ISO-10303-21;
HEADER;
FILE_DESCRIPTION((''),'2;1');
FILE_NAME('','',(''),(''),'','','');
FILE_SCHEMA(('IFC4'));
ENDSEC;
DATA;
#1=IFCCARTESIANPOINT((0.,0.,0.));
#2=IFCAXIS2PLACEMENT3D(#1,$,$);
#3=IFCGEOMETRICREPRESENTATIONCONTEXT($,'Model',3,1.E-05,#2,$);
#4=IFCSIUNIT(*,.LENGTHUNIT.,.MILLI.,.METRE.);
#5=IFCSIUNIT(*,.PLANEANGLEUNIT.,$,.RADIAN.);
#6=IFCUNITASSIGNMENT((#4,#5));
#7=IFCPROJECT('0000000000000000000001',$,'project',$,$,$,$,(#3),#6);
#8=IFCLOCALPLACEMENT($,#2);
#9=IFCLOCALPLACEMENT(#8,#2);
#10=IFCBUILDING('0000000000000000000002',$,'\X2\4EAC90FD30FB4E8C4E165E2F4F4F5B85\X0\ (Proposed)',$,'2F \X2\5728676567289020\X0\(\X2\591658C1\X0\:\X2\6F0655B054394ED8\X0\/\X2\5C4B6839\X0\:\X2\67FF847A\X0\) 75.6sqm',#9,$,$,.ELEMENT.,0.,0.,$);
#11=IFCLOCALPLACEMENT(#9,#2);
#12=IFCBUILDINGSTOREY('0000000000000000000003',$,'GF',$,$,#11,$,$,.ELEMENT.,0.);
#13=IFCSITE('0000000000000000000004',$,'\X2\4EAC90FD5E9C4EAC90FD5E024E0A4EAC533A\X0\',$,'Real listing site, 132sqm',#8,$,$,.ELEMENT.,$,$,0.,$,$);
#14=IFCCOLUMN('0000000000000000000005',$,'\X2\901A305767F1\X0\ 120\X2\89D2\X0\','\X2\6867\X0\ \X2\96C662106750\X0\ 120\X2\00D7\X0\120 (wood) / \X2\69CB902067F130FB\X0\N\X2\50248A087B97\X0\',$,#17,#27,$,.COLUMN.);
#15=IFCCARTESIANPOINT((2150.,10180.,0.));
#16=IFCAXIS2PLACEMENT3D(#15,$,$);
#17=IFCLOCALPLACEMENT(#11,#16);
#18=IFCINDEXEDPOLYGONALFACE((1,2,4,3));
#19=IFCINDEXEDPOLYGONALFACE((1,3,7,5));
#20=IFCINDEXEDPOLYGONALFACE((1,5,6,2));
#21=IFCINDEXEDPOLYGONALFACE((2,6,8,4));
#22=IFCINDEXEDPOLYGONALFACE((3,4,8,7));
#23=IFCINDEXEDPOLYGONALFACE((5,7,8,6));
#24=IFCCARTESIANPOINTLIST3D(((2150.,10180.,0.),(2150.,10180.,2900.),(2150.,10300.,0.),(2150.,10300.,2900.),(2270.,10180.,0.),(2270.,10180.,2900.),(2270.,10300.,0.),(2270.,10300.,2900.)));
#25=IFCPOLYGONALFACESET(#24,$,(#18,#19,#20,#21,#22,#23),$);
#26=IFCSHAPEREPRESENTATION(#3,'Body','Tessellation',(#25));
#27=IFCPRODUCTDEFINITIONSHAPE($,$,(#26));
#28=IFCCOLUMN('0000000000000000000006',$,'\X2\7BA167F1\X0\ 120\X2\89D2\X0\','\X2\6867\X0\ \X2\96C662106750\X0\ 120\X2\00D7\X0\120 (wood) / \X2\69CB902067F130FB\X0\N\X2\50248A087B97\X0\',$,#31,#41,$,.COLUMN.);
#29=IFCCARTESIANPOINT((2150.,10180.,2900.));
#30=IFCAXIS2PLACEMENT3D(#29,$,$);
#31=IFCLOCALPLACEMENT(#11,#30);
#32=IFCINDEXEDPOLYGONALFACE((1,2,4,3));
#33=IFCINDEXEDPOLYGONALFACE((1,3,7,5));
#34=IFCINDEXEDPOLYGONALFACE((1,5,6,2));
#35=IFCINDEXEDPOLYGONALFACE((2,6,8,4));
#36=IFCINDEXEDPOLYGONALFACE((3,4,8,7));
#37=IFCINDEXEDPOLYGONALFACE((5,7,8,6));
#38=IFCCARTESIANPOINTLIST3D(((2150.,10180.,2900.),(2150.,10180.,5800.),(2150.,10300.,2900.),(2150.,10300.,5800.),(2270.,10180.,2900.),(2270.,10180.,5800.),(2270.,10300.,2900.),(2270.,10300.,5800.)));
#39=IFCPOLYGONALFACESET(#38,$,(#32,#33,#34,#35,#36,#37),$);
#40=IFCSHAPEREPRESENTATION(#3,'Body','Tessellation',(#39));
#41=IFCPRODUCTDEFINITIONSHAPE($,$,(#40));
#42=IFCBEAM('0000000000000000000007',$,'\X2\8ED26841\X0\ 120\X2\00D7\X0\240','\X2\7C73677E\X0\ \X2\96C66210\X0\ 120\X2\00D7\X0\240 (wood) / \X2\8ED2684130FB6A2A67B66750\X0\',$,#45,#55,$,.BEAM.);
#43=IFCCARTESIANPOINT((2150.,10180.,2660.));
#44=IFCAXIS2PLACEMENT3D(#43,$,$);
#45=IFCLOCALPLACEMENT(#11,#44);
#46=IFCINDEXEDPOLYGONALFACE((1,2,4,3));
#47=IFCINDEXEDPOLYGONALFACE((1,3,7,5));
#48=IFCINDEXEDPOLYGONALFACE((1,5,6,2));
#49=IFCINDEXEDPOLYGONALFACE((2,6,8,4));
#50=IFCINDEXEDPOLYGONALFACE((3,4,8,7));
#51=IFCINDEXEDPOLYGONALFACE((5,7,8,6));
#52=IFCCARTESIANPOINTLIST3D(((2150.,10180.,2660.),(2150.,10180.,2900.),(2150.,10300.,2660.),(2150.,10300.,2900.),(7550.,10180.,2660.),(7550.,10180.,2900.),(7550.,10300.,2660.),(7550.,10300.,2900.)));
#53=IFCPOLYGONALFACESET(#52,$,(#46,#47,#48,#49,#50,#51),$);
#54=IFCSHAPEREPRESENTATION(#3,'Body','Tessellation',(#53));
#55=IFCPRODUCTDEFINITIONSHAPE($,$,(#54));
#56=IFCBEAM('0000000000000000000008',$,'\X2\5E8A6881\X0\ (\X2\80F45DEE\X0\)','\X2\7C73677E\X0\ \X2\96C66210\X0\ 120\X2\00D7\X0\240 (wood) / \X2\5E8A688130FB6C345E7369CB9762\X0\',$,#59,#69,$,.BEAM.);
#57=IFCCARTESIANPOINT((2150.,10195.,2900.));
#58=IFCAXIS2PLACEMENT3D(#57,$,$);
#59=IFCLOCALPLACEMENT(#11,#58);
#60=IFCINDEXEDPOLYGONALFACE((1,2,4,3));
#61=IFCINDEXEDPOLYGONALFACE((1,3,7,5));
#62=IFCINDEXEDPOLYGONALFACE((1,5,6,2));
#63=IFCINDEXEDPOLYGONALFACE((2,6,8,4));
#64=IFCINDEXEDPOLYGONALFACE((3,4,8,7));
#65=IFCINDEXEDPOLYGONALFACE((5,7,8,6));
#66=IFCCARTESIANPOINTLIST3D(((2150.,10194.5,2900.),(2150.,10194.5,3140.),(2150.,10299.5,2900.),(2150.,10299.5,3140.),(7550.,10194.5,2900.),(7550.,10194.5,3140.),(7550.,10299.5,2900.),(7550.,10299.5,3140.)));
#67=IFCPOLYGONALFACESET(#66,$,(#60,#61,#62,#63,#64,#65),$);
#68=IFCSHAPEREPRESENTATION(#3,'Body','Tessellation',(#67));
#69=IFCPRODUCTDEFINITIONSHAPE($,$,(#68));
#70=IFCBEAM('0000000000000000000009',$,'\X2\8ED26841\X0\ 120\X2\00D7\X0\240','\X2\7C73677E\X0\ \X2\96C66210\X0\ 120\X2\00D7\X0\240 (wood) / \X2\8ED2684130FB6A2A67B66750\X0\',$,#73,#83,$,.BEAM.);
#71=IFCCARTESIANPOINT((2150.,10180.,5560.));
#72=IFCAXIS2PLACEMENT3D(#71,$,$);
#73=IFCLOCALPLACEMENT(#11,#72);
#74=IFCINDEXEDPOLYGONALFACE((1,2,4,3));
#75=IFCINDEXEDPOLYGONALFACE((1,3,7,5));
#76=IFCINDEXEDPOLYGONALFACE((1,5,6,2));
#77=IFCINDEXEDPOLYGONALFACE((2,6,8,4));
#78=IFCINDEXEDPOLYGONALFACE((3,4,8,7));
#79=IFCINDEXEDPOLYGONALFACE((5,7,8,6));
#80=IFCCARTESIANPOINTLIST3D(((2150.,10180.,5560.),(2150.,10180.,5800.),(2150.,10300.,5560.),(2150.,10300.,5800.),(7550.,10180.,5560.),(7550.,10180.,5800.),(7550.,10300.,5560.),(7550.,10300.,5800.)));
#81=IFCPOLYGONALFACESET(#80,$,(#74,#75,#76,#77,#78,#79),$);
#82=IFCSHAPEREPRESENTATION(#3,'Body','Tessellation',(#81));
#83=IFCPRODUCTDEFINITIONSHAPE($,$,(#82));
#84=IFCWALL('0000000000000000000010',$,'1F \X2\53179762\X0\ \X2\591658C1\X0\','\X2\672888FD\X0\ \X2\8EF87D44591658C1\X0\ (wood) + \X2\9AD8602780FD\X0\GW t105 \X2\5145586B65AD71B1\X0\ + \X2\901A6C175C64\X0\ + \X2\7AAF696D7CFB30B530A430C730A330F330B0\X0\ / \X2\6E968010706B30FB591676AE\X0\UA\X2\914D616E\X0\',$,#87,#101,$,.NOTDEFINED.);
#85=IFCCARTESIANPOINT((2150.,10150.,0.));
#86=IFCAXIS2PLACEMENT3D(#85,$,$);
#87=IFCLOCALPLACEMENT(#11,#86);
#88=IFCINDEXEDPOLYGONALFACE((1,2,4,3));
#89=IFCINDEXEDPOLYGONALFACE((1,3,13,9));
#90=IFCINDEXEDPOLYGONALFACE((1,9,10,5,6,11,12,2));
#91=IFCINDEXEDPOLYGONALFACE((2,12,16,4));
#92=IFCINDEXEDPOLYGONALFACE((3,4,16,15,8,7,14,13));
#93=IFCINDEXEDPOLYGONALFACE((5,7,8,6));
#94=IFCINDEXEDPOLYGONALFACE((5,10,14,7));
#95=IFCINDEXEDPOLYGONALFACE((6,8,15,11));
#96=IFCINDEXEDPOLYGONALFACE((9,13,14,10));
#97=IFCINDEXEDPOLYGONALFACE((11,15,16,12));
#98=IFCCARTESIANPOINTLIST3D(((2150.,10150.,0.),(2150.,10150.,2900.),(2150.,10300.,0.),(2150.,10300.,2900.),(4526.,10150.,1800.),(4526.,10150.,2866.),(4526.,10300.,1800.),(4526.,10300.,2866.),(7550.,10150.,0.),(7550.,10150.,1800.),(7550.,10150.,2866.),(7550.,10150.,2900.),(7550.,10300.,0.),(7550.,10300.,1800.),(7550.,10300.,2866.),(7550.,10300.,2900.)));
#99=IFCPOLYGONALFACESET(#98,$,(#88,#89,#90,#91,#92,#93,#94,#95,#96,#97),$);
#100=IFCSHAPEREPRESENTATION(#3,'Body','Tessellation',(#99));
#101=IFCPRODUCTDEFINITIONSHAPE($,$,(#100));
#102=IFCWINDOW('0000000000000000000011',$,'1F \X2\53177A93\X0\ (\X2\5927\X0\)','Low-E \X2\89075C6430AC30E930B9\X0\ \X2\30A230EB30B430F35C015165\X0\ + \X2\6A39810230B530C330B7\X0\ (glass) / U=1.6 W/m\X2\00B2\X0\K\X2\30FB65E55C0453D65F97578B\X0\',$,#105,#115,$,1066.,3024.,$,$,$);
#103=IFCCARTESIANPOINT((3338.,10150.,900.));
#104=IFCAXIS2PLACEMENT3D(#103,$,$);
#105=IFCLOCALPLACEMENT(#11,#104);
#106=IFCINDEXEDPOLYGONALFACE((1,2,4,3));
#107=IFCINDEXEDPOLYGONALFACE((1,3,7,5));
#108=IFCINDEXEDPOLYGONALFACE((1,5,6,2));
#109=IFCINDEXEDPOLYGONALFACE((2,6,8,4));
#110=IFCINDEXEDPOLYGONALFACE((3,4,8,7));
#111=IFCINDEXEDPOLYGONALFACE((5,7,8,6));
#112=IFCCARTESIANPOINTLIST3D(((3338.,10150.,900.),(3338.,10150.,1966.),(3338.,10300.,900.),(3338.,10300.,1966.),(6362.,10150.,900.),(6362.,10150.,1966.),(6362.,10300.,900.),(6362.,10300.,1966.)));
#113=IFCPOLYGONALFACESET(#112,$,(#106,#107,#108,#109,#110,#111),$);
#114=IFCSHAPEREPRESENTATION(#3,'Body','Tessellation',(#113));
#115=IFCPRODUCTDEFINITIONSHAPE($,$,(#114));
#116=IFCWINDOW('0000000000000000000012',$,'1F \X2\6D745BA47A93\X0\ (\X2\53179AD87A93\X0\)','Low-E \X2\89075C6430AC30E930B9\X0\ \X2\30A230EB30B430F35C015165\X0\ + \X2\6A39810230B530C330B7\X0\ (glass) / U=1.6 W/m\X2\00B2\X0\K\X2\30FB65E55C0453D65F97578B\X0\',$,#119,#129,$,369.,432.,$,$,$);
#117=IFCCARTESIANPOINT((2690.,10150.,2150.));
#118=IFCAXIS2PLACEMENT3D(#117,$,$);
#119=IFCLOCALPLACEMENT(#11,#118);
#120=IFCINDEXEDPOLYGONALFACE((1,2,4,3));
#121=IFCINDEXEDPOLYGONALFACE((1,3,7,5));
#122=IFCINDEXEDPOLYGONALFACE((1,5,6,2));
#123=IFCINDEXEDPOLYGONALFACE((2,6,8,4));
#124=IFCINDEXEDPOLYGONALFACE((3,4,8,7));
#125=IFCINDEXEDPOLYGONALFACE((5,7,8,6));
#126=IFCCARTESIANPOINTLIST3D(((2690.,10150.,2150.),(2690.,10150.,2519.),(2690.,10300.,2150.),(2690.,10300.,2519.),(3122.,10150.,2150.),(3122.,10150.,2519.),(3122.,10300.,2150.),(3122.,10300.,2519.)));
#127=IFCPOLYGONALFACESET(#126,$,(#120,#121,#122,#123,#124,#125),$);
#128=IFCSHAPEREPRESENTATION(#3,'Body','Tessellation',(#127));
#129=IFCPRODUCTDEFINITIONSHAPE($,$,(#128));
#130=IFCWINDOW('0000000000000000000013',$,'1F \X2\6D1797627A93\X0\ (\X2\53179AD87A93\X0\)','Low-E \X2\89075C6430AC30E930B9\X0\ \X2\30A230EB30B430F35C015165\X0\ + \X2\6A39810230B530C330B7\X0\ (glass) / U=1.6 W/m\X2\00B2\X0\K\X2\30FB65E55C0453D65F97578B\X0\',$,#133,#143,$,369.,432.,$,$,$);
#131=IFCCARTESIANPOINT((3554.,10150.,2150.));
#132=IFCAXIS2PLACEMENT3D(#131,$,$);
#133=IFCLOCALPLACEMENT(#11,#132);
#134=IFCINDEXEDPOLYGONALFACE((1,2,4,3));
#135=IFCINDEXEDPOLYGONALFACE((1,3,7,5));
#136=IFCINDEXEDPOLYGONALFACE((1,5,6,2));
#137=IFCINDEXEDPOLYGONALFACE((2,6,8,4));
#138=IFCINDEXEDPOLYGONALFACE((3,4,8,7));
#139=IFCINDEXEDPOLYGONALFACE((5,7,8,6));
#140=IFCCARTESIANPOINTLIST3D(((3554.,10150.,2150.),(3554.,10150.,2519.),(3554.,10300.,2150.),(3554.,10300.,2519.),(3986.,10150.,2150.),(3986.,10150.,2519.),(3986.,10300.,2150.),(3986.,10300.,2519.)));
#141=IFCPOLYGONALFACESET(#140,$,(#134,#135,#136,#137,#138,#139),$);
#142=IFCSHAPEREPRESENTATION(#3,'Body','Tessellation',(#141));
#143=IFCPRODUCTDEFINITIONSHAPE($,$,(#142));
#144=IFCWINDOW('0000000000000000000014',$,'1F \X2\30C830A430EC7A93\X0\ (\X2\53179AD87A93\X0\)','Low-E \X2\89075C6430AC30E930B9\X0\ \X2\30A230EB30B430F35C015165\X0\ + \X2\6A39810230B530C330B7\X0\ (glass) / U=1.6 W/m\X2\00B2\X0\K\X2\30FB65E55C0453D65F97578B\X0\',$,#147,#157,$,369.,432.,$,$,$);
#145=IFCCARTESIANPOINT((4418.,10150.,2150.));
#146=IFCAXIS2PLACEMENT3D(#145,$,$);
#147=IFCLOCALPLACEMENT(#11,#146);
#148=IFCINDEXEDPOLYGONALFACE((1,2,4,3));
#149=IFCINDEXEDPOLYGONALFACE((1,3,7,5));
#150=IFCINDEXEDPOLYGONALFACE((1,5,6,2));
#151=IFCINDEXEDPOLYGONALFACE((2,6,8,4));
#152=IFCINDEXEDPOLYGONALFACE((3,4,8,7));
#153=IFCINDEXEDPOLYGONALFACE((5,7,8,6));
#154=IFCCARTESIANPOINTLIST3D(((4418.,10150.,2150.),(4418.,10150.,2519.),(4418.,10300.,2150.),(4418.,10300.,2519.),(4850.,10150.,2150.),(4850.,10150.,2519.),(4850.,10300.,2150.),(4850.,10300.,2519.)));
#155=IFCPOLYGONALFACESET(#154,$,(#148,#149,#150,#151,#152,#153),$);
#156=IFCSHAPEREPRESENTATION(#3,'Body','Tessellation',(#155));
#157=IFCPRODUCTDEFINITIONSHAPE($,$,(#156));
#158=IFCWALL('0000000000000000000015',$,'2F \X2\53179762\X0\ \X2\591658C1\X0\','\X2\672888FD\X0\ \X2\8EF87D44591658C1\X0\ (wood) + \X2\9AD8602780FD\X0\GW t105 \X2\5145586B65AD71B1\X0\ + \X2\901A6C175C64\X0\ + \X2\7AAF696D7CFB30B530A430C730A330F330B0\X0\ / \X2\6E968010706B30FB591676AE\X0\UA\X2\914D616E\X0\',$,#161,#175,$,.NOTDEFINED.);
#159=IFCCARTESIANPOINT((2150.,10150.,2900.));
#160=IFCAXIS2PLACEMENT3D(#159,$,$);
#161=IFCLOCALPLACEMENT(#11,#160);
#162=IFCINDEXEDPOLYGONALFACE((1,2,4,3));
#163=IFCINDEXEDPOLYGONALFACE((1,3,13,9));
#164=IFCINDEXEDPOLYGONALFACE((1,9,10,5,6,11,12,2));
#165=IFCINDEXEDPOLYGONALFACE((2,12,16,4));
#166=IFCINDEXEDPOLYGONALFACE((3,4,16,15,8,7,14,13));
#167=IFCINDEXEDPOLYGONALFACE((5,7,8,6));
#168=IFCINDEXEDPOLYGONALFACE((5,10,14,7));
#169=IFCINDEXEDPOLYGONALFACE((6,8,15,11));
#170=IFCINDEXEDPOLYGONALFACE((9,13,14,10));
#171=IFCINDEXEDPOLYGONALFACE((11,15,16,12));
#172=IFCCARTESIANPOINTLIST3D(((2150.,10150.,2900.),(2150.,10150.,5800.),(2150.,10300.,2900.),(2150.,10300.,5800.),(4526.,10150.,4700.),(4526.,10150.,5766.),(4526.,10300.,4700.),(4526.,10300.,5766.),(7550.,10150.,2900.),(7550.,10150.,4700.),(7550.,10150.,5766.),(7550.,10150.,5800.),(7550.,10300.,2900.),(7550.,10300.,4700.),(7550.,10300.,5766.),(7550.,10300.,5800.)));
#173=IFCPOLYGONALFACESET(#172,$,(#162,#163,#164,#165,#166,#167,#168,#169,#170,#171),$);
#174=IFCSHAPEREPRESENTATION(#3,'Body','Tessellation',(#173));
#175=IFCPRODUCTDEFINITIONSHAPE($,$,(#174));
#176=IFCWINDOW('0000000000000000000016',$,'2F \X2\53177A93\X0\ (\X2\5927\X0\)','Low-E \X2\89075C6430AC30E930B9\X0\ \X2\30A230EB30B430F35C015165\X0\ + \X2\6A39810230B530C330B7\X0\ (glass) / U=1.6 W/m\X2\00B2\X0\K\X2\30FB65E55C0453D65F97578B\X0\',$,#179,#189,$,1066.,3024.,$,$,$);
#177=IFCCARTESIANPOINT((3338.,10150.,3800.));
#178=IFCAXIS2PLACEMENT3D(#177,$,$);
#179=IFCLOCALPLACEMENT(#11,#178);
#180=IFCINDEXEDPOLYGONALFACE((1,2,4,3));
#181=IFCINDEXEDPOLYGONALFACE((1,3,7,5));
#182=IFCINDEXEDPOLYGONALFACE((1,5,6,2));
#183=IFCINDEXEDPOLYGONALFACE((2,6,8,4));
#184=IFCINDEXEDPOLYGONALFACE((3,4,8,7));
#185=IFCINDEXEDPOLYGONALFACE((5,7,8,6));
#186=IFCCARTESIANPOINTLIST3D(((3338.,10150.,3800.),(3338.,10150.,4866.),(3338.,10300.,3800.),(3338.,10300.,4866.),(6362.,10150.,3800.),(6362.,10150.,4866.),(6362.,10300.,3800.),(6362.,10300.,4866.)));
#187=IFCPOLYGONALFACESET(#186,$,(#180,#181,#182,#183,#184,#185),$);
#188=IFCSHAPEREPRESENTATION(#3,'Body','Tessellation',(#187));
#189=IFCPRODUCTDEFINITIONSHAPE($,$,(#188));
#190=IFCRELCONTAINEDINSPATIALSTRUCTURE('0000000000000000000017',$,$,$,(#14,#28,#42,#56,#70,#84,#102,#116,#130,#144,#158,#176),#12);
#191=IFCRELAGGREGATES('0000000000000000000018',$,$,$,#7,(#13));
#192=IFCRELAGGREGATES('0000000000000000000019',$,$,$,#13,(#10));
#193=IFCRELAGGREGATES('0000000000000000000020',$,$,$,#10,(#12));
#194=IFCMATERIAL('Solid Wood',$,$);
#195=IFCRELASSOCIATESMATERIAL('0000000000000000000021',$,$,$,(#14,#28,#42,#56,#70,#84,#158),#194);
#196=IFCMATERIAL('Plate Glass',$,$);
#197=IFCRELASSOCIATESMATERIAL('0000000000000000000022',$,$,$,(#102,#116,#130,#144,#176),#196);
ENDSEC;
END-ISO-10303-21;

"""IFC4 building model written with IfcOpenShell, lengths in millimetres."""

from ifc_helpers import new_model, si_unit, frame, frame_2d, origin, place, context, project, spatial, rectangle, extrude, material, element, fill, save


model = new_model("IFC4")

# Units and contexts
model_context = context("Model", 3, precision=1e-05, world=origin())
ifc_project = project(units=[si_unit("LENGTHUNIT", "METRE", prefix="MILLI"), si_unit("PLANEANGLEUNIT", "RADIAN")], contexts=[model_context])

# Site, building, storey
site_placement = place(None, origin())
site = spatial("IfcSite", under=ifc_project, at=site_placement, Name="京都府京都市上京区", ObjectType="Real listing site, 132sqm", CompositionType="ELEMENT", RefElevation=0.0)
building_placement = place(site_placement, origin())
building = spatial("IfcBuilding", under=site, at=building_placement, Name="京都・二世帯住宅 (Proposed)", ObjectType="2F 在来木造(外壁:漆喰吹付/屋根:柿葺) 75.6sqm", CompositionType="ELEMENT", ElevationOfRefHeight=0.0, ElevationOfTerrain=0.0)
storey_placement = place(building_placement, origin())
storey = spatial("IfcBuildingStorey", under=building, at=storey_placement, Name="GF", CompositionType="ELEMENT", Elevation=0.0)

# Columns
ifc_material_1 = material(Name="Solid Wood")
column_1_placement = place(storey_placement, frame((2150.0, 10180.0, 0.0)))
element("IfcColumn", 1, at=column_1_placement, inside=storey, material=ifc_material_1, Name="通し柱 120角", Description="桧 集成材 120×120 (wood) / 構造柱・N値計算", PredefinedType="COLUMN", context=model_context, shape_type="SweptSolid", body=[
    extrude(rectangle(XDim=120.0, YDim=120.0, at=frame_2d((60.0, 60.0))), frame((2150.0, 10180.0, 0.0)), (0.0, 0.0, 1.0), 2900.0),
])
column_2_placement = place(storey_placement, frame((2150.0, 10180.0, 2900.0)))
element("IfcColumn", 2, at=column_2_placement, inside=storey, material=ifc_material_1, Name="管柱 120角", Description="桧 集成材 120×120 (wood) / 構造柱・N値計算", PredefinedType="COLUMN", context=model_context, shape_type="SweptSolid", body=[
    extrude(rectangle(XDim=120.0, YDim=120.0, at=frame_2d((60.0, 60.0))), frame((2150.0, 10180.0, 2900.0)), (0.0, 0.0, 1.0), 2900.0),
])

# Beams
beam_1_placement = place(storey_placement, frame((2150.0, 10180.0, 2660.0)))
element("IfcBeam", 3, at=beam_1_placement, inside=storey, material=ifc_material_1, Name="軒桁 120×240", Description="米松 集成 120×240 (wood) / 軒桁・横架材", PredefinedType="BEAM", context=model_context, shape_type="SweptSolid", body=[
    extrude(rectangle(XDim=5400.0, YDim=120.0, at=frame_2d((2700.0, 60.0))), frame((2150.0, 10180.0, 2660.0)), (0.0, 0.0, 1.0), 240.0),
])
beam_2_placement = place(storey_placement, frame((2150.0, 10195.0, 2900.0)))
element("IfcBeam", 4, at=beam_2_placement, inside=storey, material=ifc_material_1, Name="床梁 (胴差)", Description="米松 集成 120×240 (wood) / 床梁・水平構面", PredefinedType="BEAM", context=model_context, shape_type="SweptSolid", body=[
    extrude(rectangle(XDim=5400.0, YDim=105.0, at=frame_2d((2700.0, 52.0))), frame((2150.0, 10195.0, 2900.0)), (0.0, 0.0, 1.0), 240.0),
])
beam_3_placement = place(storey_placement, frame((2150.0, 10180.0, 5560.0)))
element("IfcBeam", 5, at=beam_3_placement, inside=storey, material=ifc_material_1, Name="軒桁 120×240", Description="米松 集成 120×240 (wood) / 軒桁・横架材", PredefinedType="BEAM", context=model_context, shape_type="SweptSolid", body=[
    extrude(rectangle(XDim=5400.0, YDim=120.0, at=frame_2d((2700.0, 60.0))), frame((2150.0, 10180.0, 5560.0)), (0.0, 0.0, 1.0), 240.0),
])

# Wall, openings, windows
wall_1_placement = place(storey_placement, frame((2150.0, 10150.0, 0.0)))
wall_1 = element("IfcWall", 6, at=wall_1_placement, inside=storey, material=ifc_material_1, Name="1F 北面 外壁", Description="木製 軸組外壁 (wood) + 高性能GW t105 充填断熱 + 通気層 + 窯業系サイディング / 準耐火・外皮UA配慮", PredefinedType="NOTDEFINED", context=model_context, shape_type="SweptSolid", body=[
    extrude(rectangle(XDim=5400.0, YDim=150.0, at=frame_2d((2700.0, 75.0))), frame((2150.0, 10150.0, 0.0)), (0.0, 0.0, 1.0), 2900.0),
])
opening_1_placement = place(storey_placement, frame((3338.0, 10150.0, 900.0)))
opening_1 = element("IfcOpeningElement", 7, at=opening_1_placement, cuts=wall_1, PredefinedType="NOTDEFINED", context=model_context, shape_type="SweptSolid", body=[
    extrude(rectangle(XDim=3024.0, YDim=150.0, at=frame_2d((1512.0, 75.0))), frame((3338.0, 10150.0, 900.0)), (0.0, 0.0, 1.0), 1066.0),
])
opening_2_placement = place(storey_placement, frame((2690.0, 10150.0, 2150.0)))
opening_2 = element("IfcOpeningElement", 8, at=opening_2_placement, cuts=wall_1, PredefinedType="NOTDEFINED", context=model_context, shape_type="SweptSolid", body=[
    extrude(rectangle(XDim=432.0, YDim=150.0, at=frame_2d((216.0, 75.0))), frame((2690.0, 10150.0, 2150.0)), (0.0, 0.0, 1.0), 369.0),
])
opening_3_placement = place(storey_placement, frame((3554.0, 10150.0, 2150.0)))
opening_3 = element("IfcOpeningElement", 9, at=opening_3_placement, cuts=wall_1, PredefinedType="NOTDEFINED", context=model_context, shape_type="SweptSolid", body=[
    extrude(rectangle(XDim=432.0, YDim=150.0, at=frame_2d((216.0, 75.0))), frame((3554.0, 10150.0, 2150.0)), (0.0, 0.0, 1.0), 369.0),
])
opening_4_placement = place(storey_placement, frame((4418.0, 10150.0, 2150.0)))
opening_4 = element("IfcOpeningElement", 10, at=opening_4_placement, cuts=wall_1, PredefinedType="NOTDEFINED", context=model_context, shape_type="SweptSolid", body=[
    extrude(rectangle(XDim=432.0, YDim=150.0, at=frame_2d((216.0, 75.0))), frame((4418.0, 10150.0, 2150.0)), (0.0, 0.0, 1.0), 369.0),
])
ifc_material_2 = material(Name="Plate Glass")
window_1_placement = place(storey_placement, frame((3338.0, 10150.0, 900.0)))
window_1 = element("IfcWindow", 11, at=window_1_placement, inside=storey, material=ifc_material_2, Name="1F 北窓 (大)", Description="Low-E 複層ガラス アルゴン封入 + 樹脂サッシ (glass) / U=1.6 W/m²K・日射取得型", OverallHeight=1066.0, OverallWidth=3024.0, context=model_context, shape_type="SweptSolid", body=[
    extrude(rectangle(XDim=3024.0, YDim=150.0, at=frame_2d((1512.0, 75.0))), frame((3338.0, 10150.0, 900.0)), (0.0, 0.0, 1.0), 1066.0),
])
fill(opening_1, window_1)
window_2_placement = place(storey_placement, frame((2690.0, 10150.0, 2150.0)))
window_2 = element("IfcWindow", 12, at=window_2_placement, inside=storey, material=ifc_material_2, Name="1F 浴室窓 (北高窓)", Description="Low-E 複層ガラス アルゴン封入 + 樹脂サッシ (glass) / U=1.6 W/m²K・日射取得型", OverallHeight=369.0, OverallWidth=432.0, context=model_context, shape_type="SweptSolid", body=[
    extrude(rectangle(XDim=432.0, YDim=150.0, at=frame_2d((216.0, 75.0))), frame((2690.0, 10150.0, 2150.0)), (0.0, 0.0, 1.0), 369.0),
])
fill(opening_2, window_2)
window_3_placement = place(storey_placement, frame((3554.0, 10150.0, 2150.0)))
window_3 = element("IfcWindow", 13, at=window_3_placement, inside=storey, material=ifc_material_2, Name="1F 洗面窓 (北高窓)", Description="Low-E 複層ガラス アルゴン封入 + 樹脂サッシ (glass) / U=1.6 W/m²K・日射取得型", OverallHeight=369.0, OverallWidth=432.0, context=model_context, shape_type="SweptSolid", body=[
    extrude(rectangle(XDim=432.0, YDim=150.0, at=frame_2d((216.0, 75.0))), frame((3554.0, 10150.0, 2150.0)), (0.0, 0.0, 1.0), 369.0),
])
fill(opening_3, window_3)
window_4_placement = place(storey_placement, frame((4418.0, 10150.0, 2150.0)))
window_4 = element("IfcWindow", 14, at=window_4_placement, inside=storey, material=ifc_material_2, Name="1F トイレ窓 (北高窓)", Description="Low-E 複層ガラス アルゴン封入 + 樹脂サッシ (glass) / U=1.6 W/m²K・日射取得型", OverallHeight=369.0, OverallWidth=432.0, context=model_context, shape_type="SweptSolid", body=[
    extrude(rectangle(XDim=432.0, YDim=150.0, at=frame_2d((216.0, 75.0))), frame((4418.0, 10150.0, 2150.0)), (0.0, 0.0, 1.0), 369.0),
])
fill(opening_4, window_4)

# Wall, opening, window
wall_2_placement = place(storey_placement, frame((2150.0, 10150.0, 2900.0)))
wall_2 = element("IfcWall", 15, at=wall_2_placement, inside=storey, material=ifc_material_1, Name="2F 北面 外壁", Description="木製 軸組外壁 (wood) + 高性能GW t105 充填断熱 + 通気層 + 窯業系サイディング / 準耐火・外皮UA配慮", PredefinedType="NOTDEFINED", context=model_context, shape_type="SweptSolid", body=[
    extrude(rectangle(XDim=5400.0, YDim=150.0, at=frame_2d((2700.0, 75.0))), frame((2150.0, 10150.0, 2900.0)), (0.0, 0.0, 1.0), 2900.0),
])
opening_5_placement = place(storey_placement, frame((3338.0, 10150.0, 3800.0)))
opening_5 = element("IfcOpeningElement", 16, at=opening_5_placement, cuts=wall_2, PredefinedType="NOTDEFINED", context=model_context, shape_type="SweptSolid", body=[
    extrude(rectangle(XDim=3024.0, YDim=150.0, at=frame_2d((1512.0, 75.0))), frame((3338.0, 10150.0, 3800.0)), (0.0, 0.0, 1.0), 1066.0),
])
window_5_placement = place(storey_placement, frame((3338.0, 10150.0, 3800.0)))
window_5 = element("IfcWindow", 17, at=window_5_placement, inside=storey, material=ifc_material_2, Name="2F 北窓 (大)", Description="Low-E 複層ガラス アルゴン封入 + 樹脂サッシ (glass) / U=1.6 W/m²K・日射取得型", OverallHeight=1066.0, OverallWidth=3024.0, context=model_context, shape_type="SweptSolid", body=[
    extrude(rectangle(XDim=3024.0, YDim=150.0, at=frame_2d((1512.0, 75.0))), frame((3338.0, 10150.0, 3800.0)), (0.0, 0.0, 1.0), 1066.0),
])
fill(opening_5, window_5)

save(model, "model.ifc")
